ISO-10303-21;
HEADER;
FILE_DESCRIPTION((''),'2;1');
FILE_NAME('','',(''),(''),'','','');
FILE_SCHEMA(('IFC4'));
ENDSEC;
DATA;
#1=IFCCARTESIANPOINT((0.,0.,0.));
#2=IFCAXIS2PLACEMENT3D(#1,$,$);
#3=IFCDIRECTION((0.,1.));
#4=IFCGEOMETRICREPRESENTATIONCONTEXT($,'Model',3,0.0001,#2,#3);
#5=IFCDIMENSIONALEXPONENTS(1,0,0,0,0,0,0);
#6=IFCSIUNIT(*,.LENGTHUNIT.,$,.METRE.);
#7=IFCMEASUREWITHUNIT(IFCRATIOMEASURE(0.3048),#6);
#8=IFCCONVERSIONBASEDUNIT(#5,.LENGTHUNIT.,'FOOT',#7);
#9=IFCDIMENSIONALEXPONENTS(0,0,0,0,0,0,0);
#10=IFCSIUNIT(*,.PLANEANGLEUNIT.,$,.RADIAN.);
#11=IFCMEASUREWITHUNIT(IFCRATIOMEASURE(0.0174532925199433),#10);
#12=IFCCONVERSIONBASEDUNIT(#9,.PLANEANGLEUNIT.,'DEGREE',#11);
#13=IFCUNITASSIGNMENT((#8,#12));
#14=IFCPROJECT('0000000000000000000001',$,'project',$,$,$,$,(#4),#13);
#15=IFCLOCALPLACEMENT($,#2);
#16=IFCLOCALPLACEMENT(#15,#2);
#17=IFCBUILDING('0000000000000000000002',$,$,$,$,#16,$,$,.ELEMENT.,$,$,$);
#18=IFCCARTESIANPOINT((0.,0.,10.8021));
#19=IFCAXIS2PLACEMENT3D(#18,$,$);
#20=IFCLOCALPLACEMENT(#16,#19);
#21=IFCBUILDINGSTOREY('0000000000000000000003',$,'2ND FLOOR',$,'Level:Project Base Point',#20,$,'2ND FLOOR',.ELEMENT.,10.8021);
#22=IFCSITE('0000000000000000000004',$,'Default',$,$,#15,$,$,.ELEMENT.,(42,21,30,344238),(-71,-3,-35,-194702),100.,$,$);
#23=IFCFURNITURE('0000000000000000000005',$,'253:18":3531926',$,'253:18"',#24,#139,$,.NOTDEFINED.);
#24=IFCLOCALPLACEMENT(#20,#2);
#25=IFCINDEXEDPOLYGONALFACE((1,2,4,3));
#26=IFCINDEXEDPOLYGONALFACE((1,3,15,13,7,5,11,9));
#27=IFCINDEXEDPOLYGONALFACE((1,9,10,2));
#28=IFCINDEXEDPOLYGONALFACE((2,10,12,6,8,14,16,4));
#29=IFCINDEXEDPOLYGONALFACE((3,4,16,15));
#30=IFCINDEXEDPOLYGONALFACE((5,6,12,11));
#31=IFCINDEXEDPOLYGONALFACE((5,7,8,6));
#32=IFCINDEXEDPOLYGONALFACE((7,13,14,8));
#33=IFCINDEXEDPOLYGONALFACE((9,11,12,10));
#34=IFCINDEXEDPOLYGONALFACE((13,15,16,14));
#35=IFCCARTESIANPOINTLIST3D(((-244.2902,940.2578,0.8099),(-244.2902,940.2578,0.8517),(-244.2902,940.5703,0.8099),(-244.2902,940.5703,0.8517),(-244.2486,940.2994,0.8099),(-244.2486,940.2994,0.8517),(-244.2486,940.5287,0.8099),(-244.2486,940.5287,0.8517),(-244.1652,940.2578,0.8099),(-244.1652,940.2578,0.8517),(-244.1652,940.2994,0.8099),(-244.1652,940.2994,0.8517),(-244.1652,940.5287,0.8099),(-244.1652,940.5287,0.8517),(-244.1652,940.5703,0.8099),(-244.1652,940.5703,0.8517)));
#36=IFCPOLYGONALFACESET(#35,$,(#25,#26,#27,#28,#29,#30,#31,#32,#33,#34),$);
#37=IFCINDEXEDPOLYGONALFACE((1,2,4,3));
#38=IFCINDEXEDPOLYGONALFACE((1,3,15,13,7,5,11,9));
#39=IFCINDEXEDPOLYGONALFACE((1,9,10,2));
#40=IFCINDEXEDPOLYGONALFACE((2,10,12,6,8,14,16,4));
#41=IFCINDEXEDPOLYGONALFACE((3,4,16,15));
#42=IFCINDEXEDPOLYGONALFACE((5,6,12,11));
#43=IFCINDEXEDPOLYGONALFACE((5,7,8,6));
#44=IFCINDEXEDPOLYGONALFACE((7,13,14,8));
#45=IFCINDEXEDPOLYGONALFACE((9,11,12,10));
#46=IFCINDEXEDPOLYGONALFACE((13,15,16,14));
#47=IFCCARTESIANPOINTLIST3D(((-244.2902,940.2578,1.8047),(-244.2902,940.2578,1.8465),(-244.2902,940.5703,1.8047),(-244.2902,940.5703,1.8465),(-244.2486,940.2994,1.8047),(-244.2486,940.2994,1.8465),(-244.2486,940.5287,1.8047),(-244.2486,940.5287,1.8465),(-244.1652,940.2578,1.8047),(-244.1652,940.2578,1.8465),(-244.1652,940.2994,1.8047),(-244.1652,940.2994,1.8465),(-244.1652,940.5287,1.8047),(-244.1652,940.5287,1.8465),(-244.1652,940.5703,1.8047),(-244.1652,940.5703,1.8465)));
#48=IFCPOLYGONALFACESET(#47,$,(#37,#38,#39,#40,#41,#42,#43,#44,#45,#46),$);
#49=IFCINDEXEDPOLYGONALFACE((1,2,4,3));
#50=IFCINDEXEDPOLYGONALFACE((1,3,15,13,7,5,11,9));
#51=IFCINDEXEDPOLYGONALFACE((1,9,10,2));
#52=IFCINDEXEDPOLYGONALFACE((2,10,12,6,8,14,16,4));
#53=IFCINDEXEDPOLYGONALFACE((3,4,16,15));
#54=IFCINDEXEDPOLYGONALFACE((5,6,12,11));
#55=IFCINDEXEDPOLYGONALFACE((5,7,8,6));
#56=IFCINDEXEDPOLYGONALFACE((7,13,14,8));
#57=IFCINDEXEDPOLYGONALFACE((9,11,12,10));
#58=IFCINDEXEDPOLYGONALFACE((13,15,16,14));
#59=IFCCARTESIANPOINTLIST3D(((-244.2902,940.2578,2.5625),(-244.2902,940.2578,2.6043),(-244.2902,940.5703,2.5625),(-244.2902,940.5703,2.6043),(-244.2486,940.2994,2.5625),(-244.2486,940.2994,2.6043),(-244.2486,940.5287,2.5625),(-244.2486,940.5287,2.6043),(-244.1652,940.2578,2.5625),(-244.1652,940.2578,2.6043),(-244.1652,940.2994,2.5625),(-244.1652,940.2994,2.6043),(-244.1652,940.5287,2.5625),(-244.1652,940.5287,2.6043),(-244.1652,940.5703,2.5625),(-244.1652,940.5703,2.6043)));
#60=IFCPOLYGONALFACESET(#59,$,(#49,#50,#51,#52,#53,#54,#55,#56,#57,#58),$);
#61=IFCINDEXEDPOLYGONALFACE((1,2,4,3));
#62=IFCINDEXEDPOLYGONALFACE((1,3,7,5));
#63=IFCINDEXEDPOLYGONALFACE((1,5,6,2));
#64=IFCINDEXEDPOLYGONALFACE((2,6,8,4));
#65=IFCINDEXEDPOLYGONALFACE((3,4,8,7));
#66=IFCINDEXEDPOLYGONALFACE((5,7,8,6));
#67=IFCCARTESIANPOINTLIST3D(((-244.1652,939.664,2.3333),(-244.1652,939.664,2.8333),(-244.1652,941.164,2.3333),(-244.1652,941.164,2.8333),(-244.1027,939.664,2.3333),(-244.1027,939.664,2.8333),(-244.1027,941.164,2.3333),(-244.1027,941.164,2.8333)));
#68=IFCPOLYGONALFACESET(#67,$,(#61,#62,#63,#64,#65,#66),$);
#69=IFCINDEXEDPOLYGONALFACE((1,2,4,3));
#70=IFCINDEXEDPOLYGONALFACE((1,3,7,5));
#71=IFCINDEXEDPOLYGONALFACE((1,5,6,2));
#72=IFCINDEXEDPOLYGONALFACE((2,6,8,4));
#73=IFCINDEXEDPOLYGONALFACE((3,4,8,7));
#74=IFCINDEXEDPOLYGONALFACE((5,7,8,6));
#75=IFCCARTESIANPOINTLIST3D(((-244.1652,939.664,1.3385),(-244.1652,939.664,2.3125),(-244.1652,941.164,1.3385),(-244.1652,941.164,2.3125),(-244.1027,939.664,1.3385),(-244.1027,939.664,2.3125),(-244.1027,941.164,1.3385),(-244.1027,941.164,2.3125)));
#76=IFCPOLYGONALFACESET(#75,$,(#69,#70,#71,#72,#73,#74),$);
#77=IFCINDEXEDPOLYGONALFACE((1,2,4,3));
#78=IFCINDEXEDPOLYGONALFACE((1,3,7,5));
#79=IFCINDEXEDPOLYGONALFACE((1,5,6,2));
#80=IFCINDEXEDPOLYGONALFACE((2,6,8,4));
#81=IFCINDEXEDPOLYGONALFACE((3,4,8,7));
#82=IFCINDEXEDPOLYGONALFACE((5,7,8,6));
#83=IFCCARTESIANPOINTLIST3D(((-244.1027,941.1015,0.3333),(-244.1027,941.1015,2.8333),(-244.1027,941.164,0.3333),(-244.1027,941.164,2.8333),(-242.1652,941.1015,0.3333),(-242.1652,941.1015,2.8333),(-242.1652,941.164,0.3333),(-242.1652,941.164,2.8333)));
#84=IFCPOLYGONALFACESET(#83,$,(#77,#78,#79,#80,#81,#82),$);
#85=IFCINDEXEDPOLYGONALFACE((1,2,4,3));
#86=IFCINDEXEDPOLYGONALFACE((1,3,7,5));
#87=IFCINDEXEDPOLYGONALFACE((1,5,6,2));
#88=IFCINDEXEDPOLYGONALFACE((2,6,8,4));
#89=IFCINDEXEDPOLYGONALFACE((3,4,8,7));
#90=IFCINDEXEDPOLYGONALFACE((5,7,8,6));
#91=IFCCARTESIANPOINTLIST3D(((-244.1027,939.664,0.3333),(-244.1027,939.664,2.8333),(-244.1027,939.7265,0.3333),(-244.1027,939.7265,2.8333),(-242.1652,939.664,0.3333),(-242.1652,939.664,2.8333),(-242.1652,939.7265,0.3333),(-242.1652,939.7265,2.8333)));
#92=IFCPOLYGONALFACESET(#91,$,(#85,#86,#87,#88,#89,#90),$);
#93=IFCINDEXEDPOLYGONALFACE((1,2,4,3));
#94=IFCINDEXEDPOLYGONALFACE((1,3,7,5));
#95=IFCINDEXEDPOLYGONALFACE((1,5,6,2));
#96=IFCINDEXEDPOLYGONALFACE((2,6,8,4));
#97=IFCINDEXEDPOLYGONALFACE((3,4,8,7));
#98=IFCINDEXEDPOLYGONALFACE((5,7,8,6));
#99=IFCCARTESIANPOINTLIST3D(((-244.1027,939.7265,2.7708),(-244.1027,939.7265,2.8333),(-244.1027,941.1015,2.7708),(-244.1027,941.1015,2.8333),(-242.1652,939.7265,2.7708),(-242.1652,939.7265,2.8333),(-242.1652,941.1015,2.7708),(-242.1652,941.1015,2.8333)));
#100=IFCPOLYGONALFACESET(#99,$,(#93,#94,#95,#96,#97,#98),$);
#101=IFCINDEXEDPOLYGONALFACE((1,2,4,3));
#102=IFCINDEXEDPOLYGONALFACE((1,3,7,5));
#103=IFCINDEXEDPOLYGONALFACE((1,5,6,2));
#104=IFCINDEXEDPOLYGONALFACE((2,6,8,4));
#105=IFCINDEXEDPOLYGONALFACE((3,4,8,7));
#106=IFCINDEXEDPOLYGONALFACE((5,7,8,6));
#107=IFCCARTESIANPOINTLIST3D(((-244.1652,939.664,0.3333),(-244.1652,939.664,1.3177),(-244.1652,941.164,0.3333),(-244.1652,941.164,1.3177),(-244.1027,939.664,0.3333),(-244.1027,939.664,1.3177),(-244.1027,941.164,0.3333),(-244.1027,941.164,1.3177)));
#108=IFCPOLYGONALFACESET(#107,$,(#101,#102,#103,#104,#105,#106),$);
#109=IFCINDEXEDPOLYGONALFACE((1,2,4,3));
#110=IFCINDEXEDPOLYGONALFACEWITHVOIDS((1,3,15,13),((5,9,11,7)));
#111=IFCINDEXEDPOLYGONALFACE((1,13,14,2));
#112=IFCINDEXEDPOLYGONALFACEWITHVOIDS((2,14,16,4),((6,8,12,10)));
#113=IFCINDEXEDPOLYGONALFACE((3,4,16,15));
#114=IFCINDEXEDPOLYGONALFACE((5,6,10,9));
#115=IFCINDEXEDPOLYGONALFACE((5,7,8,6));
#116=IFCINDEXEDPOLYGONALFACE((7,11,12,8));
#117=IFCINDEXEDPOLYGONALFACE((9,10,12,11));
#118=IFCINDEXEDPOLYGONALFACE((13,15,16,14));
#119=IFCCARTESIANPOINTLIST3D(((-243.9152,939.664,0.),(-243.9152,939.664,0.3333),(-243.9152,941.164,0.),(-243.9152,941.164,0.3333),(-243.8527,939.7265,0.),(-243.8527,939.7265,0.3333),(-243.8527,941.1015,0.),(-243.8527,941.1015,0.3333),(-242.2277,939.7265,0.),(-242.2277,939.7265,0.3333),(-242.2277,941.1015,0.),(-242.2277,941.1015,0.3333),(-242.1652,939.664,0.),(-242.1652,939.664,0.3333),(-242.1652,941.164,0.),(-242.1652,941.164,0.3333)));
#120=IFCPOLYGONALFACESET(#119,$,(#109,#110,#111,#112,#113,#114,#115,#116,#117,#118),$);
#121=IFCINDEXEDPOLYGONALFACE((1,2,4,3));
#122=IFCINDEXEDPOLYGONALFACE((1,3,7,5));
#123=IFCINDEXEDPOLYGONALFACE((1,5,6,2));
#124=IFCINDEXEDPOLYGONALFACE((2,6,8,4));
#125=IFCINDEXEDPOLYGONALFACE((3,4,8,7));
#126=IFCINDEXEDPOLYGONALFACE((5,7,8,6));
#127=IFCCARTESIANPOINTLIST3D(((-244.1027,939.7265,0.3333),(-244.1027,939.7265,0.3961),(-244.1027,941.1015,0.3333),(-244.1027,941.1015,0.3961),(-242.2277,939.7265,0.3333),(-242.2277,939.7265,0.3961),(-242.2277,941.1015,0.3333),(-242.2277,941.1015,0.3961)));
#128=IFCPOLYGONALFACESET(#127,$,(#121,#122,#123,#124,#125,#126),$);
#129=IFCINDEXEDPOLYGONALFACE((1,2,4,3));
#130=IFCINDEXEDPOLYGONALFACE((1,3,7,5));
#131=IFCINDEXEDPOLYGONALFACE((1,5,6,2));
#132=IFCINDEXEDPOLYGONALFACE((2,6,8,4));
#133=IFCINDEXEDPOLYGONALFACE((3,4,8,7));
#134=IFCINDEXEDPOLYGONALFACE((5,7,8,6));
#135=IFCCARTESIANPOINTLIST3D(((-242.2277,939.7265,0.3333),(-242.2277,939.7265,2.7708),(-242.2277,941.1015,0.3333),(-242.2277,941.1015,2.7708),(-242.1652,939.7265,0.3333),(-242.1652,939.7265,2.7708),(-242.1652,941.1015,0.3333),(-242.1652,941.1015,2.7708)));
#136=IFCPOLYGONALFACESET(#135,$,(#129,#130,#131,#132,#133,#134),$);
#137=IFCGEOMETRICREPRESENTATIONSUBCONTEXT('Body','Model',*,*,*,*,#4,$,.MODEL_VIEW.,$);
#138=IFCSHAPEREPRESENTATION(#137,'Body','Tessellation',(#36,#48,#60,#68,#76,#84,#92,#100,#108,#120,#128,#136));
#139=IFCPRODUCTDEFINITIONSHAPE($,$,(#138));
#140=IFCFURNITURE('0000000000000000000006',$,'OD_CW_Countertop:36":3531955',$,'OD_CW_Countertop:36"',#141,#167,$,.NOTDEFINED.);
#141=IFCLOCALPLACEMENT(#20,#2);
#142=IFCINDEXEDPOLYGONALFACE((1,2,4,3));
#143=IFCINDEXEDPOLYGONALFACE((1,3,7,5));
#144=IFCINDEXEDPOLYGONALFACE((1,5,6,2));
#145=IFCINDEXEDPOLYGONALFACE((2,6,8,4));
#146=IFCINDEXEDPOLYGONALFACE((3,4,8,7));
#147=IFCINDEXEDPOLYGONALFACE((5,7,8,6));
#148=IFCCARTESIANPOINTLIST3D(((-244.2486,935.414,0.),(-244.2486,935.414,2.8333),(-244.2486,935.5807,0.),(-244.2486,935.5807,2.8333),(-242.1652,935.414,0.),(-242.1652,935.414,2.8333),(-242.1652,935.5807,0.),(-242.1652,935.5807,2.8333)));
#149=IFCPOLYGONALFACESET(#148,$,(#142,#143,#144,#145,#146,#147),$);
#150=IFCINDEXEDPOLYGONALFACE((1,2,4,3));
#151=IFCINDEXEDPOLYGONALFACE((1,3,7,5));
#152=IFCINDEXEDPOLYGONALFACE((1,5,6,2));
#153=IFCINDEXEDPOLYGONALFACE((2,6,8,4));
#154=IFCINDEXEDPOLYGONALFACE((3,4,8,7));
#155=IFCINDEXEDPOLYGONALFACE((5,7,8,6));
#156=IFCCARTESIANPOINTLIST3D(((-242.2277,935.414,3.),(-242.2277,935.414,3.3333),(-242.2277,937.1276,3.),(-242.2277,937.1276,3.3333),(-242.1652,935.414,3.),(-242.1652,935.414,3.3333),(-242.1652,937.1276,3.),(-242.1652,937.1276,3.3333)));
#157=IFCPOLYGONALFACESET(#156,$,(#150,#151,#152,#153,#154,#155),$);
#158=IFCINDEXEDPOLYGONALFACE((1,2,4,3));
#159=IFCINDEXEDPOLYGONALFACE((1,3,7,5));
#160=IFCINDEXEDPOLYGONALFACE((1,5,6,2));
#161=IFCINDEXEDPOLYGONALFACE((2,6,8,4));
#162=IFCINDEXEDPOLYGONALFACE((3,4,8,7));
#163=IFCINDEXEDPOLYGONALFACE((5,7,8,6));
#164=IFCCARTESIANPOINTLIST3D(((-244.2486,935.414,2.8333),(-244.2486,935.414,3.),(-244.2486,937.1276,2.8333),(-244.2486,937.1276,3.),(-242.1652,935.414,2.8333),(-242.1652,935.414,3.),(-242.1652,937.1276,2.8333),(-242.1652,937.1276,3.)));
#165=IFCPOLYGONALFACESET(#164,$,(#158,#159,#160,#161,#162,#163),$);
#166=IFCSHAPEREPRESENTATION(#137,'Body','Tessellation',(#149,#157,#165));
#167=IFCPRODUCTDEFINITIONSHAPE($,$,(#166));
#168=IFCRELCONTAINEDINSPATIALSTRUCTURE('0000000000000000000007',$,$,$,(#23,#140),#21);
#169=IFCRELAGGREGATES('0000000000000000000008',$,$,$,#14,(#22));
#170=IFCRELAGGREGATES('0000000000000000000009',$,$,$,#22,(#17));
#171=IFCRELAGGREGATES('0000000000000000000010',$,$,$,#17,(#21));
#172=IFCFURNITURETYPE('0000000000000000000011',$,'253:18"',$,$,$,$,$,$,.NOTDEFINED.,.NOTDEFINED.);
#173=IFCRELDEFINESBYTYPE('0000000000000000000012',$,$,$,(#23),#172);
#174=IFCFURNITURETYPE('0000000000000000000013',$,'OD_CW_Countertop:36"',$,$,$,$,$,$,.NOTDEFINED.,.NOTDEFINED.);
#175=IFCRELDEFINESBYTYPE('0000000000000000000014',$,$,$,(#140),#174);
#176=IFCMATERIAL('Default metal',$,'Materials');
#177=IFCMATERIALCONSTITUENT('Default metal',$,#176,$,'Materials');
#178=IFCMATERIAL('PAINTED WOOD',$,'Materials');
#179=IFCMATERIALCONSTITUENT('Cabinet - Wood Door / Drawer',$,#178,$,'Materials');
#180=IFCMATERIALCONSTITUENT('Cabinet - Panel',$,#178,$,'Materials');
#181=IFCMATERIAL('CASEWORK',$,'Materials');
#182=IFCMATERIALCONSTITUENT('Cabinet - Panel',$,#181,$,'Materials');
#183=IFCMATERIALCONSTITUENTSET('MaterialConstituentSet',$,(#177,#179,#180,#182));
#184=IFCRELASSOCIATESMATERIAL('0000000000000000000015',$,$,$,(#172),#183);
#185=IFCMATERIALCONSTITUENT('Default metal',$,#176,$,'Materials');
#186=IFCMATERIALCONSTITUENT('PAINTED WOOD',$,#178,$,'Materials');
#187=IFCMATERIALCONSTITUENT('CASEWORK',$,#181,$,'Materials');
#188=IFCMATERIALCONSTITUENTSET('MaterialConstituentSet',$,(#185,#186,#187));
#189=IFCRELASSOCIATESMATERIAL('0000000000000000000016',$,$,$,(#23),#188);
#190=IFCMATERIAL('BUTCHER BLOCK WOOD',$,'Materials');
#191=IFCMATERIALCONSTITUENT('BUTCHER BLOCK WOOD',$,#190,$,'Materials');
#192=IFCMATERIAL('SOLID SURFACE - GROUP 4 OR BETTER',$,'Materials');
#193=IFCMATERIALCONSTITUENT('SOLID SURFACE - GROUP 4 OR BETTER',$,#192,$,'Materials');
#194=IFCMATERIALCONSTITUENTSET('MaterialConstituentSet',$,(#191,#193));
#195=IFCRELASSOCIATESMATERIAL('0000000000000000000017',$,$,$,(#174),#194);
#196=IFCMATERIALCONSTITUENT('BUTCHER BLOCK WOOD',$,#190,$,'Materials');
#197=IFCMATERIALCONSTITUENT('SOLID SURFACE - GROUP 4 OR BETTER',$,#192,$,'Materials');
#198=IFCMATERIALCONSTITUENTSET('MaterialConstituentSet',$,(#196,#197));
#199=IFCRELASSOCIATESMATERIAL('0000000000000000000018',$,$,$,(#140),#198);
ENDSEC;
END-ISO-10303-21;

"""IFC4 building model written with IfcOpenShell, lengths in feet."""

from ifc_helpers import new_model, entity, si_unit, converted_unit, direction, frame, frame_2d, origin, origin_2d_with_axis, place, context, subcontext, project, spatial, polyline, rectangle, outline, extrude, source, transform, mapped, material, constituent, constituent_set, type_object, type_shapes, element, save


model = new_model("IFC4")

# Units and contexts
model_context = context("Model", 3, precision=0.0001, world=origin(), true_north=direction((0.0, 1.0)))
body_context = subcontext(model_context, "Body", "Model", "MODEL_VIEW")
ifc_project = project(units=[converted_unit("LENGTHUNIT", "FOOT", entity("IfcRatioMeasure", 0.3048), si_unit("LENGTHUNIT", "METRE"), dimensions=[1, 0, 0, 0, 0, 0, 0]), converted_unit("PLANEANGLEUNIT", "DEGREE", entity("IfcRatioMeasure", 0.0174532925199433), si_unit("PLANEANGLEUNIT", "RADIAN"), dimensions=[0, 0, 0, 0, 0, 0, 0])], contexts=[model_context])

# Site, building, storey
site_placement = place(None, origin())
site = spatial("IfcSite", under=ifc_project, at=site_placement, Name="Default", CompositionType="ELEMENT", RefLatitude=(42, 21, 30, 344238), RefLongitude=(-71, -3, -35, -194702), RefElevation=100.0)
building_placement = place(site_placement, origin())
building = spatial("IfcBuilding", under=site, at=building_placement, CompositionType="ELEMENT")
storey_placement = place(building_placement, frame((0.0, 0.0, 10.8021)))
storey = spatial("IfcBuildingStorey", under=building, at=storey_placement, Name="2ND FLOOR", ObjectType="Level:Project Base Point", LongName="2ND FLOOR", CompositionType="ELEMENT", Elevation=10.8021)

# Shared definitions
ifc_material_1 = material(Name="Default metal", Category="Materials")
ifc_material_2 = material(Name="PAINTED WOOD", Category="Materials")
ifc_material_3 = material(Name="CASEWORK", Category="Materials")

# Furniture
ifc_constituent_1 = constituent(ifc_material_1, Name="Default metal", Category="Materials")
ifc_constituent_2 = constituent(ifc_material_2, Name="PAINTED WOOD", Category="Materials")
ifc_constituent_3 = constituent(ifc_material_3, Name="CASEWORK", Category="Materials")
ifc_constituent_set_1 = constituent_set(constituents=[ifc_constituent_1, ifc_constituent_2, ifc_constituent_3], Name="MaterialConstituentSet")
ifc_constituent_4 = constituent(ifc_material_1, Name="Default metal", Category="Materials")
ifc_constituent_5 = constituent(ifc_material_2, Name="Cabinet - Wood Door / Drawer", Category="Materials")
ifc_constituent_6 = constituent(ifc_material_2, Name="Cabinet - Panel", Category="Materials")
ifc_constituent_7 = constituent(ifc_material_3, Name="Cabinet - Panel", Category="Materials")
ifc_constituent_set_2 = constituent_set(constituents=[ifc_constituent_4, ifc_constituent_5, ifc_constituent_6, ifc_constituent_7], Name="MaterialConstituentSet")
furniture_type_1 = type_object("IfcFurnitureType", Name="253:18\"", AssemblyPlace="NOTDEFINED", PredefinedType="NOTDEFINED", material=ifc_constituent_set_2)
shared_shape_1 = source(origin(), body_context, "Body", "SweptSolid", [
    extrude(outline(polyline([(-0.0521, -0.1562), (0.0729, -0.1562), (0.0729, 0.1562), (-0.0521, 0.1562), (-0.0521, 0.1146), (0.0313, 0.1146), (0.0313, -0.1146), (-0.0521, -0.1146), (-0.0521, -0.1562)])), frame((0.0615, -2.0521, 0.8099), z_axis=(0.0, 0.0, 1.0), x_axis=(0.0, -1.0, 0.0)), (0.0, 0.0, 1.0), 0.0418),
    extrude(outline(polyline([(-0.0521, -0.1562), (0.0729, -0.1562), (0.0729, 0.1562), (-0.0521, 0.1562), (-0.0521, 0.1146), (0.0313, 0.1146), (0.0313, -0.1146), (-0.0521, -0.1146), (-0.0521, -0.1562)])), frame((0.0615, -2.0521, 1.8047), z_axis=(0.0, 0.0, 1.0), x_axis=(0.0, -1.0, 0.0)), (0.0, 0.0, 1.0), 0.0418),
    extrude(outline(polyline([(-0.0521, -0.1562), (0.0729, -0.1562), (0.0729, 0.1562), (-0.0521, 0.1562), (-0.0521, 0.1146), (0.0313, 0.1146), (0.0313, -0.1146), (-0.0521, -0.1146), (-0.0521, -0.1562)])), frame((0.0615, -2.0521, 2.5625), z_axis=(0.0, 0.0, 1.0), x_axis=(0.0, -1.0, 0.0)), (0.0, 0.0, 1.0), 0.0418),
    extrude(rectangle(XDim=0.0625, YDim=1.5, at=frame_2d((0.0, 0.0), x_axis=(1.0, 0.0))), frame((0.0615, -1.9688, 2.3333), z_axis=(0.0, 0.0, 1.0), x_axis=(0.0, 1.0, 0.0)), (0.0, 0.0, 1.0), 0.5),
    extrude(rectangle(XDim=0.0625, YDim=1.5, at=frame_2d((0.0, 0.0), x_axis=(1.0, 0.0))), frame((0.0615, -1.9688, 1.3385), z_axis=(0.0, 0.0, 1.0), x_axis=(0.0, 1.0, 0.0)), (0.0, 0.0, 1.0), 0.974),
    extrude(rectangle(XDim=0.0625, YDim=1.9375, at=frame_2d((0.0, 0.0), x_axis=(1.0, 0.0))), frame((-0.6573, -0.9687, 0.3333)), (0.0, 0.0, 1.0), 2.5),
    extrude(rectangle(XDim=0.0625, YDim=1.9375, at=frame_2d((0.0, 0.0), x_axis=(1.0, 0.0))), frame((0.7802, -0.9687, 0.3333)), (0.0, 0.0, 1.0), 2.5),
    extrude(rectangle(XDim=1.375, YDim=1.9375, at=origin_2d_with_axis()), frame((0.0615, -0.9688, 2.7708), z_axis=(0.0, 0.0, 1.0), x_axis=(-1.0, 0.0, 0.0)), (0.0, 0.0, 1.0), 0.0625),
    extrude(rectangle(XDim=0.0625, YDim=1.5, at=frame_2d((0.0, 0.0), x_axis=(1.0, 0.0))), frame((0.0615, -1.9688, 0.3333), z_axis=(0.0, 0.0, 1.0), x_axis=(0.0, 1.0, 0.0)), (0.0, 0.0, 1.0), 0.9844),
    extrude(outline(polyline([(-0.75, -0.875), (0.75, -0.875), (0.75, 0.875), (-0.75, 0.875), (-0.75, -0.875)]), holes=[polyline([(-0.6875, -0.8125), (-0.6875, 0.8125), (0.6875, 0.8125), (0.6875, -0.8125), (-0.6875, -0.8125)])]), frame((0.0615, -0.875, 0.0)), (0.0, 0.0, 1.0), 0.3333),
    extrude(rectangle(XDim=1.375, YDim=1.875, at=frame_2d((0.0, 0.0), x_axis=(1.0, 0.0))), frame((0.0615, -1.0, 0.3333), z_axis=(0.0, 0.0, 1.0), x_axis=(-1.0, 0.0, 0.0)), (0.0, 0.0, 1.0), 0.0627),
    extrude(rectangle(XDim=0.0625, YDim=1.375, at=origin_2d_with_axis()), frame((0.0615, -0.0312, 0.3333), z_axis=(0.0, 0.0, 1.0), x_axis=(0.0, 1.0, 0.0)), (0.0, 0.0, 1.0), 2.4375),
])
type_shapes(furniture_type_1, [shared_shape_1])
furniture_1_placement = place(storey_placement, frame((-242.1652, 940.4755, 0.0), z_axis=(0.0, 0.0, 1.0), x_axis=(0.0, -1.0, 0.0)))
element("IfcFurniture", 1, at=furniture_1_placement, inside=storey, type_object=furniture_type_1, material=ifc_constituent_set_1, Name="253:18\":3531926", ObjectType="253:18\"", PredefinedType="NOTDEFINED", context=body_context, shape_type="MappedRepresentation", body=[
    mapped(shared_shape_1, transform((0.0, 0.0, 0.0), scale=1.0)),
])
ifc_material_4 = material(Name="BUTCHER BLOCK WOOD", Category="Materials")
ifc_constituent_8 = constituent(ifc_material_4, Name="BUTCHER BLOCK WOOD", Category="Materials")
ifc_material_5 = material(Name="SOLID SURFACE - GROUP 4 OR BETTER", Category="Materials")
ifc_constituent_9 = constituent(ifc_material_5, Name="SOLID SURFACE - GROUP 4 OR BETTER", Category="Materials")
ifc_constituent_set_3 = constituent_set(constituents=[ifc_constituent_8, ifc_constituent_9], Name="MaterialConstituentSet")
ifc_constituent_10 = constituent(ifc_material_4, Name="BUTCHER BLOCK WOOD", Category="Materials")
ifc_constituent_11 = constituent(ifc_material_5, Name="SOLID SURFACE - GROUP 4 OR BETTER", Category="Materials")
ifc_constituent_set_4 = constituent_set(constituents=[ifc_constituent_10, ifc_constituent_11], Name="MaterialConstituentSet")
furniture_type_2 = type_object("IfcFurnitureType", Name="OD_CW_Countertop:36\"", AssemblyPlace="NOTDEFINED", PredefinedType="NOTDEFINED", material=ifc_constituent_set_4)
shared_shape_2 = source(origin(), body_context, "Body", "SweptSolid", [
    extrude(rectangle(XDim=0.1667, YDim=2.0833, at=frame_2d((0.0, 0.0), x_axis=(1.0, 0.0))), frame((0.0833, 1.0417, 0.0)), (0.0, 0.0, 1.0), 2.8333),
    extrude(rectangle(XDim=1.7135, YDim=0.0625, at=origin_2d_with_axis()), frame((0.8568, 0.0313, 3.0)), (0.0, 0.0, 1.0), 0.3333),
    extrude(rectangle(XDim=1.7135, YDim=2.0833, at=origin_2d_with_axis()), frame((0.8568, 1.0417, 2.8333)), (0.0, 0.0, 1.0), 0.1667),
])
type_shapes(furniture_type_2, [shared_shape_2])
furniture_2_placement = place(storey_placement, frame((-242.1652, 935.414, 0.0), z_axis=(0.0, 0.0, 1.0), x_axis=(0.0, 1.0, 0.0)))
element("IfcFurniture", 2, at=furniture_2_placement, inside=storey, type_object=furniture_type_2, material=ifc_constituent_set_3, Name="OD_CW_Countertop:36\":3531955", ObjectType="OD_CW_Countertop:36\"", PredefinedType="NOTDEFINED", context=body_context, shape_type="MappedRepresentation", body=[
    mapped(shared_shape_2, transform((0.0, 0.0, 0.0), scale=1.0)),
])

save(model, "model.ifc")
